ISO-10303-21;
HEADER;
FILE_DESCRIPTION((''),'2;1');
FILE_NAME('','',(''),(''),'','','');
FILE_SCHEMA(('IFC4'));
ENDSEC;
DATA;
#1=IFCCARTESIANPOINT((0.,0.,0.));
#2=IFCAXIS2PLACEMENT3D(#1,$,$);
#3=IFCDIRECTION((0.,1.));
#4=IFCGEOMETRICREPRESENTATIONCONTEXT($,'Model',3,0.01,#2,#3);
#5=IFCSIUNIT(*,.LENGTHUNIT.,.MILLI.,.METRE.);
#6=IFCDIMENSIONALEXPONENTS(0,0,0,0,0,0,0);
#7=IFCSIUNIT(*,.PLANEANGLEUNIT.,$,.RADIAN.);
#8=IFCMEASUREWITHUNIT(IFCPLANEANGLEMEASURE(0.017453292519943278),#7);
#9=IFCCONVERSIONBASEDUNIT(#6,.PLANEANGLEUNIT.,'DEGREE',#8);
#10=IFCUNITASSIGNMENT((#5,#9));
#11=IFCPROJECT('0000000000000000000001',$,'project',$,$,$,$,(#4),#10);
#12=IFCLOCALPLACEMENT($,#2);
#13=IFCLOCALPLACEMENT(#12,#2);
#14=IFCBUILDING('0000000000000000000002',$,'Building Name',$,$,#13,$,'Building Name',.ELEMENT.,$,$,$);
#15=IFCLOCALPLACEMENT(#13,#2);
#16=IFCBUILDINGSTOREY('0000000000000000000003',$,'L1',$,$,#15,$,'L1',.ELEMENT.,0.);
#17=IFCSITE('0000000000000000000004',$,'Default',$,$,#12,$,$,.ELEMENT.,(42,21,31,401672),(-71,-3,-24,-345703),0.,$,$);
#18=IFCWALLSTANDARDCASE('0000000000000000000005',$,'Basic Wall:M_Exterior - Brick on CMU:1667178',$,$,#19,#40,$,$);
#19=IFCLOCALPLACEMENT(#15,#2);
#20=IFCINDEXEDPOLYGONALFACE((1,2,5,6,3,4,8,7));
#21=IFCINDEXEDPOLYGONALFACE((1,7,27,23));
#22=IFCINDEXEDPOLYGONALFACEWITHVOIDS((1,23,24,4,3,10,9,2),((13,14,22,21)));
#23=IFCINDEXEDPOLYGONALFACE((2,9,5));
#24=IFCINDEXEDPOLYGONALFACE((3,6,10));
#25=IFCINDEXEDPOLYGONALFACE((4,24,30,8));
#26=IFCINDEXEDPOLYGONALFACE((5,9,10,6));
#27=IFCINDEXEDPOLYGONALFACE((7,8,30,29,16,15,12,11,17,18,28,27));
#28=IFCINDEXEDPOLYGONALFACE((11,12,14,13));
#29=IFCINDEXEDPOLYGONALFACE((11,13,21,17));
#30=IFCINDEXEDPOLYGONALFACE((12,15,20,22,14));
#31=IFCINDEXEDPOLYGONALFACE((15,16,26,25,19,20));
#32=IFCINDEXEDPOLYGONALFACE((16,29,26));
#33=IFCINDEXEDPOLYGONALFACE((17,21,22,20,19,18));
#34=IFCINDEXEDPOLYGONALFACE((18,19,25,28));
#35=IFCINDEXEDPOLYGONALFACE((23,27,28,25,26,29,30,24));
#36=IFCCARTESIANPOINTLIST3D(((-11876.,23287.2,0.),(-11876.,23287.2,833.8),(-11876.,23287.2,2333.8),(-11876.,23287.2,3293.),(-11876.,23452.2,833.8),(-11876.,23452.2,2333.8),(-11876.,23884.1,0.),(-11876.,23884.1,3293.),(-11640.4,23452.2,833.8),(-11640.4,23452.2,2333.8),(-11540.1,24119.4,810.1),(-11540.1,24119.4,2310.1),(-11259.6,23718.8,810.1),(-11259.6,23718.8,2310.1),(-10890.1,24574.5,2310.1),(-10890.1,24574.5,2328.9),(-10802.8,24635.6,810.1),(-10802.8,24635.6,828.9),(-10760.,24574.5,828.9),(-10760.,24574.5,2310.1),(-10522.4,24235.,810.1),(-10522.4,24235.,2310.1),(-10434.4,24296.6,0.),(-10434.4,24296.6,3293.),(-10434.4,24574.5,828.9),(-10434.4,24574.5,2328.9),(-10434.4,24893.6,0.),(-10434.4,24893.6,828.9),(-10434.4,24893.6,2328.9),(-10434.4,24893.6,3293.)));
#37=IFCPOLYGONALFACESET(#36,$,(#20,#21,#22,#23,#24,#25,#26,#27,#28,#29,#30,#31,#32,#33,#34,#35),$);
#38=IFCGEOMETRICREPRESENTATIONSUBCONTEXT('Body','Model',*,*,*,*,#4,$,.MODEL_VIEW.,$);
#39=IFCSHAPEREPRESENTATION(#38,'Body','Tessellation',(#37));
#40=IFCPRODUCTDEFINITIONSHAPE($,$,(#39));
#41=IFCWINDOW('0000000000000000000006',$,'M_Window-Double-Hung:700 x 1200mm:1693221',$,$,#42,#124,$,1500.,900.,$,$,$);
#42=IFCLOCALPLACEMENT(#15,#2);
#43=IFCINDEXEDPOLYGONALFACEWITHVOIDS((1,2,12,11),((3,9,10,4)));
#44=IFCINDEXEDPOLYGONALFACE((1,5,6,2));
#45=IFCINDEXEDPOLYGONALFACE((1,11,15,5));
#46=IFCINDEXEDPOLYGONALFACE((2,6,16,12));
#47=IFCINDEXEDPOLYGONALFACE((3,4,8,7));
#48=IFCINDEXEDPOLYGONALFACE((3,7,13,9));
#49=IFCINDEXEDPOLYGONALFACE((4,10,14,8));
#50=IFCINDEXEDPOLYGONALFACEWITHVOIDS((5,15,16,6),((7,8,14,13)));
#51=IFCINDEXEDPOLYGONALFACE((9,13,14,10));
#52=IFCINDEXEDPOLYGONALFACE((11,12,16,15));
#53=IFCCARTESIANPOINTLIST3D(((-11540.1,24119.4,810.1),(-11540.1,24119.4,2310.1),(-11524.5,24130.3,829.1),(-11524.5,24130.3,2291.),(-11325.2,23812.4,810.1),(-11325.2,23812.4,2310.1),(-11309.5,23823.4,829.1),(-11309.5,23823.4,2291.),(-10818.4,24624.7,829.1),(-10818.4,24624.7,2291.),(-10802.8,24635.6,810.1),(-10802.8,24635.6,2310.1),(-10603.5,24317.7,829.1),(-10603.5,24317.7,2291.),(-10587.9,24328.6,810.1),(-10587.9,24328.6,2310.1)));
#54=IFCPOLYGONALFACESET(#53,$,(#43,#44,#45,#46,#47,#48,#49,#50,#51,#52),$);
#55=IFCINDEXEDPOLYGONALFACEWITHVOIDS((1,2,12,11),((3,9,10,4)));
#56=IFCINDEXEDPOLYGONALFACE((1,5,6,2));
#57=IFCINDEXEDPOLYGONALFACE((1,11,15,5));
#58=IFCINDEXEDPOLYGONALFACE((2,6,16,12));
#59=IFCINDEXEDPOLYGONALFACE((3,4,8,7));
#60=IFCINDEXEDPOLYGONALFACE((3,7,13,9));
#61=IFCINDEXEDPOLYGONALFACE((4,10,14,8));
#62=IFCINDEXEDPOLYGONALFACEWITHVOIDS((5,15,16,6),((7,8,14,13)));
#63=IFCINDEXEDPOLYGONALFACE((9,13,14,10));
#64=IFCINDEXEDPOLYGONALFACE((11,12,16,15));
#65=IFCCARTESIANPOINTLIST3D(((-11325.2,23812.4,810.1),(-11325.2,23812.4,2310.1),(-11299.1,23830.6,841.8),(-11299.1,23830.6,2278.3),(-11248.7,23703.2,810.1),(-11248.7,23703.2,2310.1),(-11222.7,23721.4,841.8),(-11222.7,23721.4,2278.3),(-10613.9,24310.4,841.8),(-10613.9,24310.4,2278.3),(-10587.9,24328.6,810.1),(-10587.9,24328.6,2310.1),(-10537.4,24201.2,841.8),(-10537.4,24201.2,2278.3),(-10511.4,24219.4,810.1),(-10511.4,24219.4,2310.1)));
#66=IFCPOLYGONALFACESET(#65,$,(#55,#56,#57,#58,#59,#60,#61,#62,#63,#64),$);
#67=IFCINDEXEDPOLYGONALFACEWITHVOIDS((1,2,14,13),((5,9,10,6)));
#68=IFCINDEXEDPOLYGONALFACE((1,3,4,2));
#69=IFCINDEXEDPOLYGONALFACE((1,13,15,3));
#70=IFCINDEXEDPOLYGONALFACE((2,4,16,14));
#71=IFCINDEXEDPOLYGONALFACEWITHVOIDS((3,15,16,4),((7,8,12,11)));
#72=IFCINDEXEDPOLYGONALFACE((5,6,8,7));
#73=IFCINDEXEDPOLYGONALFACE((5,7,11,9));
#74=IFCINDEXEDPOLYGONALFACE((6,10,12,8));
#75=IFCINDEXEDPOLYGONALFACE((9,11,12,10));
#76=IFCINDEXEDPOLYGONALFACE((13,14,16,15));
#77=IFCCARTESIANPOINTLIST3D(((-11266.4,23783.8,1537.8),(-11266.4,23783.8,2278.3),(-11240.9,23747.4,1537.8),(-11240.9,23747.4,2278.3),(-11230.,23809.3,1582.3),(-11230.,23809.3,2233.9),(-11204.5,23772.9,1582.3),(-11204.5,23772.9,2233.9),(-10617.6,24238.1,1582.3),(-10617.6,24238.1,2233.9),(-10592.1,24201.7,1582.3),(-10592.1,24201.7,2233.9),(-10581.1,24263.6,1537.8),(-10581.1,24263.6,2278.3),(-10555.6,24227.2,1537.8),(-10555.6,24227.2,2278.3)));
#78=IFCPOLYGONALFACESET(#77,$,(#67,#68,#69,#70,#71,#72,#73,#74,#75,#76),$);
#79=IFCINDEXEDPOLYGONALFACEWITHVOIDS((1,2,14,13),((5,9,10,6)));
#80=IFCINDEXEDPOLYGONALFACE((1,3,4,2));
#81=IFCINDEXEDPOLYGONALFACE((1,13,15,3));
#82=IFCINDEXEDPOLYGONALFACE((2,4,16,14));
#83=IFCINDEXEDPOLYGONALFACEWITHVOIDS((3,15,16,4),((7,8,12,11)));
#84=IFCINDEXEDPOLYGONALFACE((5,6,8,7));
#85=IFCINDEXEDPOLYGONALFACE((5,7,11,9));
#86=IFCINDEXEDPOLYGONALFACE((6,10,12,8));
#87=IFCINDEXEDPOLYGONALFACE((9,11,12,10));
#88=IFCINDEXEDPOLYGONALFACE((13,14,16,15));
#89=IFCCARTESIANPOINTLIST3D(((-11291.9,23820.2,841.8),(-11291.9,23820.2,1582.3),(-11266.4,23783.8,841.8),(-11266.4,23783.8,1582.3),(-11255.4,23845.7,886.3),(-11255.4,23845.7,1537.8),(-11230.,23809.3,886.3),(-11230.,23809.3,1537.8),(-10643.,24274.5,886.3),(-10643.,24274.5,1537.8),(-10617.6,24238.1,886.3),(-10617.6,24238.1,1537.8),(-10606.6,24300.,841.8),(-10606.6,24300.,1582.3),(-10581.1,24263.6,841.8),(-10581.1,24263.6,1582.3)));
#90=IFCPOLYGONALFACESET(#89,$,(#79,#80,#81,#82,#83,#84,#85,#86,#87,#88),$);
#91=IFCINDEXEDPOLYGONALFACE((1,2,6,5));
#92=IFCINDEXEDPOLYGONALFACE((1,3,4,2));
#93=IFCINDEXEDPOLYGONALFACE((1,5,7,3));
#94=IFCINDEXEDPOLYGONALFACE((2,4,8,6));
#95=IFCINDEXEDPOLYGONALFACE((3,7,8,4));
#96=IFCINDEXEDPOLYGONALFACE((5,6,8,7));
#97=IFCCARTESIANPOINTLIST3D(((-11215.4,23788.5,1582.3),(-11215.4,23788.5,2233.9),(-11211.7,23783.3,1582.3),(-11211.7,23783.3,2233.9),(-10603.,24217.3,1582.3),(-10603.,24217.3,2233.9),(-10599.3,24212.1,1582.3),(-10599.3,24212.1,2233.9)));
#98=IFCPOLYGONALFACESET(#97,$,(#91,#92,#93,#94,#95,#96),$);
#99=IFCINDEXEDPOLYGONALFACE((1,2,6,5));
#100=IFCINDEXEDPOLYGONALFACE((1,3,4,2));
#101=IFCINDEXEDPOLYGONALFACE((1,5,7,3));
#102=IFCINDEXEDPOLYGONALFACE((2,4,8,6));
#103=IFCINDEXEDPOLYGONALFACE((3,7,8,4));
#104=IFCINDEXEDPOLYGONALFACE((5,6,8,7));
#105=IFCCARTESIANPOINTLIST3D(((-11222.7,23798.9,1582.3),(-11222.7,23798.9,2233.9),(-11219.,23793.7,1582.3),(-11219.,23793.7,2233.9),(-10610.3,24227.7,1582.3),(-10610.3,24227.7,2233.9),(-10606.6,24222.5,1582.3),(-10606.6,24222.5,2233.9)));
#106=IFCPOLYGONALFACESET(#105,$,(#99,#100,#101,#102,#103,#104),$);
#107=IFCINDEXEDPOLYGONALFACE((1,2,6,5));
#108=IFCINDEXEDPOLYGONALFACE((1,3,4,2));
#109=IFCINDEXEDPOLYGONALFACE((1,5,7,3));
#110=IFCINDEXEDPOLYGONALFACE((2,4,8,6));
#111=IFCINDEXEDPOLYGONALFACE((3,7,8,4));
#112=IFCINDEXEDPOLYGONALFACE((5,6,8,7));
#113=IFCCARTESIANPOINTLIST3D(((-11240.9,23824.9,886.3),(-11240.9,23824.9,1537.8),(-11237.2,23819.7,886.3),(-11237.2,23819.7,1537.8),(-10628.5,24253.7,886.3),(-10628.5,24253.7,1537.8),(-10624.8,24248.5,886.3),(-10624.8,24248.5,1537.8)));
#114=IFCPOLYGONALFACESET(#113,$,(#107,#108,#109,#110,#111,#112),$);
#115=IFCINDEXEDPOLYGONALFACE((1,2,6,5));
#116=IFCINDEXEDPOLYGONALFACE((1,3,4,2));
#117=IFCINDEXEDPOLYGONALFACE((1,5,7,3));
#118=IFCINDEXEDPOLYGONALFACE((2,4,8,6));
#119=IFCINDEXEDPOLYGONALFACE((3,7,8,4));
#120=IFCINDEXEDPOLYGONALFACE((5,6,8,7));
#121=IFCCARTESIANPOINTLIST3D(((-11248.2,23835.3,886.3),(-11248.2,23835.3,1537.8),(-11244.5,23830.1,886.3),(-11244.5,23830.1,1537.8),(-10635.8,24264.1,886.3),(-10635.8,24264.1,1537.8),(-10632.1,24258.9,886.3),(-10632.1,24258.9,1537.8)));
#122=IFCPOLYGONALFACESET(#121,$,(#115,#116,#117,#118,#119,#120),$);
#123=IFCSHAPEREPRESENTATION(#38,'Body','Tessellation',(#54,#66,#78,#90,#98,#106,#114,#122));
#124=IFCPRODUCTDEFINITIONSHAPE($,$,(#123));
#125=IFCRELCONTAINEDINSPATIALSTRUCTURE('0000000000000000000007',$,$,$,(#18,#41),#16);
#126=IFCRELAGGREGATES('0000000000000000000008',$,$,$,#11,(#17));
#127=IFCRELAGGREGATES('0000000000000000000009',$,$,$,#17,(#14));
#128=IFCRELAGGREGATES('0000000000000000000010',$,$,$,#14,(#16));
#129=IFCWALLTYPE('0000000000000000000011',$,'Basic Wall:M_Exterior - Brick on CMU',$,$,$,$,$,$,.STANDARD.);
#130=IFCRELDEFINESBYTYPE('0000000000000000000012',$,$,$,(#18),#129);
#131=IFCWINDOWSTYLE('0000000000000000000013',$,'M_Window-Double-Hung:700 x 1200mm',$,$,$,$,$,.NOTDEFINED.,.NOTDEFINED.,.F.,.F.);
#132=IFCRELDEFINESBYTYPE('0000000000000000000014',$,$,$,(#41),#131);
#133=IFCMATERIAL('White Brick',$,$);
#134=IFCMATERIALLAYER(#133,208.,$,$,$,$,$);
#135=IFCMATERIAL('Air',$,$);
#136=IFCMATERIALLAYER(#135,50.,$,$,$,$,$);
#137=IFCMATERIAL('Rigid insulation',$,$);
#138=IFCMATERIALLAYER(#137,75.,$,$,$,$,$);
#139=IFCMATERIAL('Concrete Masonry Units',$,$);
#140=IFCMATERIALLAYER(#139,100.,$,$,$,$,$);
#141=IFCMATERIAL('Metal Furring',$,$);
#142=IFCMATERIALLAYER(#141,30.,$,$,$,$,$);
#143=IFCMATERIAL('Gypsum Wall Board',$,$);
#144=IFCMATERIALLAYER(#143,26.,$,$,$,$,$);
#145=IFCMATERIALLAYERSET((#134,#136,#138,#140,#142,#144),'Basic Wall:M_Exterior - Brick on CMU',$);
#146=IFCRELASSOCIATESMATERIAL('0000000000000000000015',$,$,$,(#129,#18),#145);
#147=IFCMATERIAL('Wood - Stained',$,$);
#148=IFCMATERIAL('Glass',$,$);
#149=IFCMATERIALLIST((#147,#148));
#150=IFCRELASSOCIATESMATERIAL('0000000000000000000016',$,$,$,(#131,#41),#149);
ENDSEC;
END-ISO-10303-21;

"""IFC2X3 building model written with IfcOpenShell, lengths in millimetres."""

from ifc_helpers import new_model, entity, si_unit, converted_unit, direction, frame, frame_2d, origin, place, context, subcontext, project, spatial, polyline, rectangle, outline, extrude, clip, bounded_halfspace, source, transform, mapped, material, material_list, layer, layer_set, layer_usage, type_object, type_shapes, element, fill, save


model = new_model("IFC2X3")

# Units and contexts
model_context = context("Model", 3, precision=0.01, world=origin(), true_north=direction((0.0, 1.0)))
body_context = subcontext(model_context, "Body", "Model", "MODEL_VIEW")
ifc_project = project(units=[si_unit("LENGTHUNIT", "METRE", prefix="MILLI"), converted_unit("PLANEANGLEUNIT", "DEGREE", entity("IfcPlaneAngleMeasure", 0.017453292519943278), si_unit("PLANEANGLEUNIT", "RADIAN"), dimensions=[0, 0, 0, 0, 0, 0, 0])], contexts=[model_context])

# Site, building, storey
site_placement = place(None, origin())
site = spatial("IfcSite", under=ifc_project, at=site_placement, Name="Default", CompositionType="ELEMENT", RefLatitude=(42, 21, 31, 401672), RefLongitude=(-71, -3, -24, -345703), RefElevation=0.0)
building_placement = place(site_placement, origin())
building = spatial("IfcBuilding", under=site, at=building_placement, Name="Building Name", LongName="Building Name", CompositionType="ELEMENT")
storey_placement = place(building_placement, origin())
storey = spatial("IfcBuildingStorey", under=building, at=storey_placement, Name="L1", LongName="L1", CompositionType="ELEMENT", Elevation=0.0)

# Wall, openings, window
ifc_material_1 = material(Name="White Brick")
ifc_layer_1 = layer(ifc_material_1, 208.0)
ifc_material_2 = material(Name="Air")
ifc_layer_2 = layer(ifc_material_2, 50.0)
ifc_material_3 = material(Name="Rigid insulation")
ifc_layer_3 = layer(ifc_material_3, 75.0)
ifc_material_4 = material(Name="Concrete Masonry Units")
ifc_layer_4 = layer(ifc_material_4, 100.0)
ifc_material_5 = material(Name="Metal Furring")
ifc_layer_5 = layer(ifc_material_5, 30.0)
ifc_material_6 = material(Name="Gypsum Wall Board")
ifc_layer_6 = layer(ifc_material_6, 26.0)
ifc_layer_set_1 = layer_set([ifc_layer_1, ifc_layer_2, ifc_layer_3, ifc_layer_4, ifc_layer_5, ifc_layer_6], Name="Basic Wall:M_Exterior - Brick on CMU")
ifc_layer_usage_1 = layer_usage(ifc_layer_set_1, "AXIS2", "POSITIVE", -244.5)
wall_type_1 = type_object("IfcWallType", Name="Basic Wall:M_Exterior - Brick on CMU", PredefinedType="STANDARD", material=ifc_layer_set_1)
wall_1_placement = place(storey_placement, frame((-12016.3, 23487.4, 0.0), z_axis=(0.0, 0.0, 1.0), x_axis=(0.819152, 0.573576, 0.0)))
wall_1 = element("IfcWallStandardCase", 1, at=wall_1_placement, inside=storey, type_object=wall_type_1, material=ifc_layer_usage_1, Name="Basic Wall:M_Exterior - Brick on CMU:1667178", context=body_context, shape_type="Clipping", body=[
    clip(extrude(outline(polyline([(1759.9, -244.5), (2102.3, 244.5), (1505.3, 244.5), (342.4, 244.5), (0.0, -244.5), (597.0, -244.5), (1759.9, -244.5)])), origin(), (0.0, 0.0, 1.0), 3293.0), bounded_halfspace(frame((0.0, -244.5, 3293.0), z_axis=(0.0, 0.0, -1.0), x_axis=(-0.573576, -0.819152, 0.0)), True, frame((0.0, -244.5, 3293.0)), polyline([(0.0, 0.0), (1759.9, 0.0), (2102.3, 489.0), (1505.3, 489.0), (342.4, 489.0), (0.0, 0.0)]))),
])
opening_1_placement = place(wall_1_placement, origin())
element("IfcOpeningElement", 2, at=opening_1_placement, cuts=wall_1, ObjectType="Opening", context=body_context, shape_type="SweptSolid", body=[
    extrude(rectangle(XDim=1500.0, YDim=489.0, at=frame_2d((0.0, 0.0), x_axis=(0.0, 1.0))), frame((-393.4, -1232.6, 1583.8), z_axis=(0.573576, 0.819152, 0.0), x_axis=(0.819152, -0.573576, 0.0)), (0.0, 0.0, 1.0), 1200.0),
])
opening_2_placement = place(wall_1_placement, origin())
element("IfcOpeningElement", 3, at=opening_2_placement, cuts=wall_1, ObjectType="Opening", context=body_context, shape_type="SweptSolid", body=[
    extrude(rectangle(XDim=1500.0, YDim=489.0, at=frame_2d((0.0, 0.0), x_axis=(0.0, 1.0))), frame((1719.0, 123.4, 1578.9), z_axis=(0.573576, 0.819152, 0.0), x_axis=(0.819152, -0.573576, 0.0)), (0.0, 0.0, 1.0), 1200.0),
])
opening_3_placement = place(wall_1_placement, frame((1652.5, 244.5, 810.1)))
opening_3 = element("IfcOpeningElement", 4, at=opening_3_placement, cuts=wall_1, ObjectType="Opening", context=body_context, shape_type="SweptSolid", body=[
    extrude(rectangle(XDim=1500.0, YDim=900.0, at=frame_2d((750.0, 450.0), x_axis=(-1.0, 0.0))), frame((0.0, 0.0, 0.0), z_axis=(0.0, -1.0, 0.0), x_axis=(0.0, 0.0, 1.0)), (0.0, 0.0, 1.0), 489.0),
])
ifc_material_7 = material(Name="Wood - Stained")
ifc_material_8 = material(Name="Glass")
ifc_material_list_1 = material_list([ifc_material_7, ifc_material_8])
window_style_1 = type_object("IfcWindowStyle", Name="M_Window-Double-Hung:700 x 1200mm", ConstructionType="NOTDEFINED", OperationType="NOTDEFINED", ParameterTakesPrecedence=False, Sizeable=False, material=ifc_material_list_1)
shared_shape_1 = source(origin(), body_context, "Body", "SweptSolid", [
    extrude(outline(polyline([(-750.0, -450.0), (750.0, -450.0), (750.0, 450.0), (-750.0, 450.0), (-750.0, -450.0)]), holes=[polyline([(-730.9, -430.9), (-730.9, 430.9), (730.9, 430.9), (730.9, -430.9), (-730.9, -430.9)])]), frame((450.0, 0.0, 750.0), z_axis=(0.0, 1.0, 0.0), x_axis=(0.0, 0.0, -1.0)), (0.0, 0.0, 1.0), 374.7),
    extrude(outline(polyline([(-450.0, -750.0), (450.0, -750.0), (450.0, 750.0), (-450.0, 750.0), (-450.0, -750.0)]), holes=[polyline([(418.2, -718.2), (-418.2, -718.2), (-418.2, 718.2), (418.2, 718.2), (418.2, -718.2)])]), frame((450.0, 374.7, 750.0), z_axis=(0.0, 1.0, 0.0), x_axis=(1.0, 0.0, 0.0)), (0.0, 0.0, 1.0), 133.3),
    extrude(outline(polyline([(-418.2, -370.2), (418.2, -370.2), (418.2, 370.2), (-418.2, 370.2), (-418.2, -370.2)]), holes=[polyline([(373.8, -325.8), (-373.8, -325.8), (-373.8, 325.8), (373.8, 325.8), (373.8, -325.8)])]), frame((450.0, 431.8, 1098.0), z_axis=(0.0, 1.0, 0.0), x_axis=(1.0, 0.0, 0.0)), (0.0, 0.0, 1.0), 44.4),
    extrude(outline(polyline([(-418.2, -370.2), (418.2, -370.2), (418.2, 370.2), (-418.2, 370.2), (-418.2, -370.2)]), holes=[polyline([(373.8, -325.8), (-373.8, -325.8), (-373.8, 325.8), (373.8, 325.8), (373.8, -325.8)])]), frame((450.0, 387.4, 402.0), z_axis=(0.0, 1.0, 0.0), x_axis=(1.0, 0.0, 0.0)), (0.0, 0.0, 1.0), 44.5),
    extrude(rectangle(XDim=747.6, YDim=6.4, at=frame_2d((0.0, 0.0), x_axis=(1.0, 0.0))), frame((450.0, 460.4, 772.2), z_axis=(0.0, 0.0, 1.0), x_axis=(-1.0, 0.0, 0.0)), (0.0, 0.0, 1.0), 651.6),
    extrude(rectangle(XDim=6.4, YDim=747.6, at=frame_2d((0.0, 0.0), x_axis=(1.0, 0.0))), frame((450.0, 447.7, 772.2), z_axis=(0.0, 0.0, 1.0), x_axis=(0.0, -1.0, 0.0)), (0.0, 0.0, 1.0), 651.6),
    extrude(rectangle(XDim=747.6, YDim=6.4, at=frame_2d((0.0, 0.0), x_axis=(1.0, 0.0))), frame((450.0, 416.0, 76.2), z_axis=(0.0, 0.0, 1.0), x_axis=(-1.0, 0.0, 0.0)), (0.0, 0.0, 1.0), 651.6),
    extrude(rectangle(XDim=6.4, YDim=747.6, at=frame_2d((0.0, 0.0), x_axis=(1.0, 0.0))), frame((450.0, 403.3, 76.2), z_axis=(0.0, 0.0, 1.0), x_axis=(0.0, -1.0, 0.0)), (0.0, 0.0, 1.0), 651.6),
])
type_shapes(window_style_1, [shared_shape_1])
window_1_placement = place(opening_3_placement, frame((0.0, 0.0, 0.0), z_axis=(0.0, 0.0, 1.0), x_axis=(-1.0, 0.0, 0.0)))
window_1 = element("IfcWindow", 5, at=window_1_placement, inside=storey, type_object=window_style_1, material=ifc_material_list_1, Name="M_Window-Double-Hung:700 x 1200mm:1693221", OverallHeight=1500.0, OverallWidth=900.0, context=body_context, shape_type="MappedRepresentation", body=[
    mapped(shared_shape_1, transform((0.0, 0.0, 0.0), scale=1.0)),
])
fill(opening_3, window_1)

save(model, "model.ifc")
